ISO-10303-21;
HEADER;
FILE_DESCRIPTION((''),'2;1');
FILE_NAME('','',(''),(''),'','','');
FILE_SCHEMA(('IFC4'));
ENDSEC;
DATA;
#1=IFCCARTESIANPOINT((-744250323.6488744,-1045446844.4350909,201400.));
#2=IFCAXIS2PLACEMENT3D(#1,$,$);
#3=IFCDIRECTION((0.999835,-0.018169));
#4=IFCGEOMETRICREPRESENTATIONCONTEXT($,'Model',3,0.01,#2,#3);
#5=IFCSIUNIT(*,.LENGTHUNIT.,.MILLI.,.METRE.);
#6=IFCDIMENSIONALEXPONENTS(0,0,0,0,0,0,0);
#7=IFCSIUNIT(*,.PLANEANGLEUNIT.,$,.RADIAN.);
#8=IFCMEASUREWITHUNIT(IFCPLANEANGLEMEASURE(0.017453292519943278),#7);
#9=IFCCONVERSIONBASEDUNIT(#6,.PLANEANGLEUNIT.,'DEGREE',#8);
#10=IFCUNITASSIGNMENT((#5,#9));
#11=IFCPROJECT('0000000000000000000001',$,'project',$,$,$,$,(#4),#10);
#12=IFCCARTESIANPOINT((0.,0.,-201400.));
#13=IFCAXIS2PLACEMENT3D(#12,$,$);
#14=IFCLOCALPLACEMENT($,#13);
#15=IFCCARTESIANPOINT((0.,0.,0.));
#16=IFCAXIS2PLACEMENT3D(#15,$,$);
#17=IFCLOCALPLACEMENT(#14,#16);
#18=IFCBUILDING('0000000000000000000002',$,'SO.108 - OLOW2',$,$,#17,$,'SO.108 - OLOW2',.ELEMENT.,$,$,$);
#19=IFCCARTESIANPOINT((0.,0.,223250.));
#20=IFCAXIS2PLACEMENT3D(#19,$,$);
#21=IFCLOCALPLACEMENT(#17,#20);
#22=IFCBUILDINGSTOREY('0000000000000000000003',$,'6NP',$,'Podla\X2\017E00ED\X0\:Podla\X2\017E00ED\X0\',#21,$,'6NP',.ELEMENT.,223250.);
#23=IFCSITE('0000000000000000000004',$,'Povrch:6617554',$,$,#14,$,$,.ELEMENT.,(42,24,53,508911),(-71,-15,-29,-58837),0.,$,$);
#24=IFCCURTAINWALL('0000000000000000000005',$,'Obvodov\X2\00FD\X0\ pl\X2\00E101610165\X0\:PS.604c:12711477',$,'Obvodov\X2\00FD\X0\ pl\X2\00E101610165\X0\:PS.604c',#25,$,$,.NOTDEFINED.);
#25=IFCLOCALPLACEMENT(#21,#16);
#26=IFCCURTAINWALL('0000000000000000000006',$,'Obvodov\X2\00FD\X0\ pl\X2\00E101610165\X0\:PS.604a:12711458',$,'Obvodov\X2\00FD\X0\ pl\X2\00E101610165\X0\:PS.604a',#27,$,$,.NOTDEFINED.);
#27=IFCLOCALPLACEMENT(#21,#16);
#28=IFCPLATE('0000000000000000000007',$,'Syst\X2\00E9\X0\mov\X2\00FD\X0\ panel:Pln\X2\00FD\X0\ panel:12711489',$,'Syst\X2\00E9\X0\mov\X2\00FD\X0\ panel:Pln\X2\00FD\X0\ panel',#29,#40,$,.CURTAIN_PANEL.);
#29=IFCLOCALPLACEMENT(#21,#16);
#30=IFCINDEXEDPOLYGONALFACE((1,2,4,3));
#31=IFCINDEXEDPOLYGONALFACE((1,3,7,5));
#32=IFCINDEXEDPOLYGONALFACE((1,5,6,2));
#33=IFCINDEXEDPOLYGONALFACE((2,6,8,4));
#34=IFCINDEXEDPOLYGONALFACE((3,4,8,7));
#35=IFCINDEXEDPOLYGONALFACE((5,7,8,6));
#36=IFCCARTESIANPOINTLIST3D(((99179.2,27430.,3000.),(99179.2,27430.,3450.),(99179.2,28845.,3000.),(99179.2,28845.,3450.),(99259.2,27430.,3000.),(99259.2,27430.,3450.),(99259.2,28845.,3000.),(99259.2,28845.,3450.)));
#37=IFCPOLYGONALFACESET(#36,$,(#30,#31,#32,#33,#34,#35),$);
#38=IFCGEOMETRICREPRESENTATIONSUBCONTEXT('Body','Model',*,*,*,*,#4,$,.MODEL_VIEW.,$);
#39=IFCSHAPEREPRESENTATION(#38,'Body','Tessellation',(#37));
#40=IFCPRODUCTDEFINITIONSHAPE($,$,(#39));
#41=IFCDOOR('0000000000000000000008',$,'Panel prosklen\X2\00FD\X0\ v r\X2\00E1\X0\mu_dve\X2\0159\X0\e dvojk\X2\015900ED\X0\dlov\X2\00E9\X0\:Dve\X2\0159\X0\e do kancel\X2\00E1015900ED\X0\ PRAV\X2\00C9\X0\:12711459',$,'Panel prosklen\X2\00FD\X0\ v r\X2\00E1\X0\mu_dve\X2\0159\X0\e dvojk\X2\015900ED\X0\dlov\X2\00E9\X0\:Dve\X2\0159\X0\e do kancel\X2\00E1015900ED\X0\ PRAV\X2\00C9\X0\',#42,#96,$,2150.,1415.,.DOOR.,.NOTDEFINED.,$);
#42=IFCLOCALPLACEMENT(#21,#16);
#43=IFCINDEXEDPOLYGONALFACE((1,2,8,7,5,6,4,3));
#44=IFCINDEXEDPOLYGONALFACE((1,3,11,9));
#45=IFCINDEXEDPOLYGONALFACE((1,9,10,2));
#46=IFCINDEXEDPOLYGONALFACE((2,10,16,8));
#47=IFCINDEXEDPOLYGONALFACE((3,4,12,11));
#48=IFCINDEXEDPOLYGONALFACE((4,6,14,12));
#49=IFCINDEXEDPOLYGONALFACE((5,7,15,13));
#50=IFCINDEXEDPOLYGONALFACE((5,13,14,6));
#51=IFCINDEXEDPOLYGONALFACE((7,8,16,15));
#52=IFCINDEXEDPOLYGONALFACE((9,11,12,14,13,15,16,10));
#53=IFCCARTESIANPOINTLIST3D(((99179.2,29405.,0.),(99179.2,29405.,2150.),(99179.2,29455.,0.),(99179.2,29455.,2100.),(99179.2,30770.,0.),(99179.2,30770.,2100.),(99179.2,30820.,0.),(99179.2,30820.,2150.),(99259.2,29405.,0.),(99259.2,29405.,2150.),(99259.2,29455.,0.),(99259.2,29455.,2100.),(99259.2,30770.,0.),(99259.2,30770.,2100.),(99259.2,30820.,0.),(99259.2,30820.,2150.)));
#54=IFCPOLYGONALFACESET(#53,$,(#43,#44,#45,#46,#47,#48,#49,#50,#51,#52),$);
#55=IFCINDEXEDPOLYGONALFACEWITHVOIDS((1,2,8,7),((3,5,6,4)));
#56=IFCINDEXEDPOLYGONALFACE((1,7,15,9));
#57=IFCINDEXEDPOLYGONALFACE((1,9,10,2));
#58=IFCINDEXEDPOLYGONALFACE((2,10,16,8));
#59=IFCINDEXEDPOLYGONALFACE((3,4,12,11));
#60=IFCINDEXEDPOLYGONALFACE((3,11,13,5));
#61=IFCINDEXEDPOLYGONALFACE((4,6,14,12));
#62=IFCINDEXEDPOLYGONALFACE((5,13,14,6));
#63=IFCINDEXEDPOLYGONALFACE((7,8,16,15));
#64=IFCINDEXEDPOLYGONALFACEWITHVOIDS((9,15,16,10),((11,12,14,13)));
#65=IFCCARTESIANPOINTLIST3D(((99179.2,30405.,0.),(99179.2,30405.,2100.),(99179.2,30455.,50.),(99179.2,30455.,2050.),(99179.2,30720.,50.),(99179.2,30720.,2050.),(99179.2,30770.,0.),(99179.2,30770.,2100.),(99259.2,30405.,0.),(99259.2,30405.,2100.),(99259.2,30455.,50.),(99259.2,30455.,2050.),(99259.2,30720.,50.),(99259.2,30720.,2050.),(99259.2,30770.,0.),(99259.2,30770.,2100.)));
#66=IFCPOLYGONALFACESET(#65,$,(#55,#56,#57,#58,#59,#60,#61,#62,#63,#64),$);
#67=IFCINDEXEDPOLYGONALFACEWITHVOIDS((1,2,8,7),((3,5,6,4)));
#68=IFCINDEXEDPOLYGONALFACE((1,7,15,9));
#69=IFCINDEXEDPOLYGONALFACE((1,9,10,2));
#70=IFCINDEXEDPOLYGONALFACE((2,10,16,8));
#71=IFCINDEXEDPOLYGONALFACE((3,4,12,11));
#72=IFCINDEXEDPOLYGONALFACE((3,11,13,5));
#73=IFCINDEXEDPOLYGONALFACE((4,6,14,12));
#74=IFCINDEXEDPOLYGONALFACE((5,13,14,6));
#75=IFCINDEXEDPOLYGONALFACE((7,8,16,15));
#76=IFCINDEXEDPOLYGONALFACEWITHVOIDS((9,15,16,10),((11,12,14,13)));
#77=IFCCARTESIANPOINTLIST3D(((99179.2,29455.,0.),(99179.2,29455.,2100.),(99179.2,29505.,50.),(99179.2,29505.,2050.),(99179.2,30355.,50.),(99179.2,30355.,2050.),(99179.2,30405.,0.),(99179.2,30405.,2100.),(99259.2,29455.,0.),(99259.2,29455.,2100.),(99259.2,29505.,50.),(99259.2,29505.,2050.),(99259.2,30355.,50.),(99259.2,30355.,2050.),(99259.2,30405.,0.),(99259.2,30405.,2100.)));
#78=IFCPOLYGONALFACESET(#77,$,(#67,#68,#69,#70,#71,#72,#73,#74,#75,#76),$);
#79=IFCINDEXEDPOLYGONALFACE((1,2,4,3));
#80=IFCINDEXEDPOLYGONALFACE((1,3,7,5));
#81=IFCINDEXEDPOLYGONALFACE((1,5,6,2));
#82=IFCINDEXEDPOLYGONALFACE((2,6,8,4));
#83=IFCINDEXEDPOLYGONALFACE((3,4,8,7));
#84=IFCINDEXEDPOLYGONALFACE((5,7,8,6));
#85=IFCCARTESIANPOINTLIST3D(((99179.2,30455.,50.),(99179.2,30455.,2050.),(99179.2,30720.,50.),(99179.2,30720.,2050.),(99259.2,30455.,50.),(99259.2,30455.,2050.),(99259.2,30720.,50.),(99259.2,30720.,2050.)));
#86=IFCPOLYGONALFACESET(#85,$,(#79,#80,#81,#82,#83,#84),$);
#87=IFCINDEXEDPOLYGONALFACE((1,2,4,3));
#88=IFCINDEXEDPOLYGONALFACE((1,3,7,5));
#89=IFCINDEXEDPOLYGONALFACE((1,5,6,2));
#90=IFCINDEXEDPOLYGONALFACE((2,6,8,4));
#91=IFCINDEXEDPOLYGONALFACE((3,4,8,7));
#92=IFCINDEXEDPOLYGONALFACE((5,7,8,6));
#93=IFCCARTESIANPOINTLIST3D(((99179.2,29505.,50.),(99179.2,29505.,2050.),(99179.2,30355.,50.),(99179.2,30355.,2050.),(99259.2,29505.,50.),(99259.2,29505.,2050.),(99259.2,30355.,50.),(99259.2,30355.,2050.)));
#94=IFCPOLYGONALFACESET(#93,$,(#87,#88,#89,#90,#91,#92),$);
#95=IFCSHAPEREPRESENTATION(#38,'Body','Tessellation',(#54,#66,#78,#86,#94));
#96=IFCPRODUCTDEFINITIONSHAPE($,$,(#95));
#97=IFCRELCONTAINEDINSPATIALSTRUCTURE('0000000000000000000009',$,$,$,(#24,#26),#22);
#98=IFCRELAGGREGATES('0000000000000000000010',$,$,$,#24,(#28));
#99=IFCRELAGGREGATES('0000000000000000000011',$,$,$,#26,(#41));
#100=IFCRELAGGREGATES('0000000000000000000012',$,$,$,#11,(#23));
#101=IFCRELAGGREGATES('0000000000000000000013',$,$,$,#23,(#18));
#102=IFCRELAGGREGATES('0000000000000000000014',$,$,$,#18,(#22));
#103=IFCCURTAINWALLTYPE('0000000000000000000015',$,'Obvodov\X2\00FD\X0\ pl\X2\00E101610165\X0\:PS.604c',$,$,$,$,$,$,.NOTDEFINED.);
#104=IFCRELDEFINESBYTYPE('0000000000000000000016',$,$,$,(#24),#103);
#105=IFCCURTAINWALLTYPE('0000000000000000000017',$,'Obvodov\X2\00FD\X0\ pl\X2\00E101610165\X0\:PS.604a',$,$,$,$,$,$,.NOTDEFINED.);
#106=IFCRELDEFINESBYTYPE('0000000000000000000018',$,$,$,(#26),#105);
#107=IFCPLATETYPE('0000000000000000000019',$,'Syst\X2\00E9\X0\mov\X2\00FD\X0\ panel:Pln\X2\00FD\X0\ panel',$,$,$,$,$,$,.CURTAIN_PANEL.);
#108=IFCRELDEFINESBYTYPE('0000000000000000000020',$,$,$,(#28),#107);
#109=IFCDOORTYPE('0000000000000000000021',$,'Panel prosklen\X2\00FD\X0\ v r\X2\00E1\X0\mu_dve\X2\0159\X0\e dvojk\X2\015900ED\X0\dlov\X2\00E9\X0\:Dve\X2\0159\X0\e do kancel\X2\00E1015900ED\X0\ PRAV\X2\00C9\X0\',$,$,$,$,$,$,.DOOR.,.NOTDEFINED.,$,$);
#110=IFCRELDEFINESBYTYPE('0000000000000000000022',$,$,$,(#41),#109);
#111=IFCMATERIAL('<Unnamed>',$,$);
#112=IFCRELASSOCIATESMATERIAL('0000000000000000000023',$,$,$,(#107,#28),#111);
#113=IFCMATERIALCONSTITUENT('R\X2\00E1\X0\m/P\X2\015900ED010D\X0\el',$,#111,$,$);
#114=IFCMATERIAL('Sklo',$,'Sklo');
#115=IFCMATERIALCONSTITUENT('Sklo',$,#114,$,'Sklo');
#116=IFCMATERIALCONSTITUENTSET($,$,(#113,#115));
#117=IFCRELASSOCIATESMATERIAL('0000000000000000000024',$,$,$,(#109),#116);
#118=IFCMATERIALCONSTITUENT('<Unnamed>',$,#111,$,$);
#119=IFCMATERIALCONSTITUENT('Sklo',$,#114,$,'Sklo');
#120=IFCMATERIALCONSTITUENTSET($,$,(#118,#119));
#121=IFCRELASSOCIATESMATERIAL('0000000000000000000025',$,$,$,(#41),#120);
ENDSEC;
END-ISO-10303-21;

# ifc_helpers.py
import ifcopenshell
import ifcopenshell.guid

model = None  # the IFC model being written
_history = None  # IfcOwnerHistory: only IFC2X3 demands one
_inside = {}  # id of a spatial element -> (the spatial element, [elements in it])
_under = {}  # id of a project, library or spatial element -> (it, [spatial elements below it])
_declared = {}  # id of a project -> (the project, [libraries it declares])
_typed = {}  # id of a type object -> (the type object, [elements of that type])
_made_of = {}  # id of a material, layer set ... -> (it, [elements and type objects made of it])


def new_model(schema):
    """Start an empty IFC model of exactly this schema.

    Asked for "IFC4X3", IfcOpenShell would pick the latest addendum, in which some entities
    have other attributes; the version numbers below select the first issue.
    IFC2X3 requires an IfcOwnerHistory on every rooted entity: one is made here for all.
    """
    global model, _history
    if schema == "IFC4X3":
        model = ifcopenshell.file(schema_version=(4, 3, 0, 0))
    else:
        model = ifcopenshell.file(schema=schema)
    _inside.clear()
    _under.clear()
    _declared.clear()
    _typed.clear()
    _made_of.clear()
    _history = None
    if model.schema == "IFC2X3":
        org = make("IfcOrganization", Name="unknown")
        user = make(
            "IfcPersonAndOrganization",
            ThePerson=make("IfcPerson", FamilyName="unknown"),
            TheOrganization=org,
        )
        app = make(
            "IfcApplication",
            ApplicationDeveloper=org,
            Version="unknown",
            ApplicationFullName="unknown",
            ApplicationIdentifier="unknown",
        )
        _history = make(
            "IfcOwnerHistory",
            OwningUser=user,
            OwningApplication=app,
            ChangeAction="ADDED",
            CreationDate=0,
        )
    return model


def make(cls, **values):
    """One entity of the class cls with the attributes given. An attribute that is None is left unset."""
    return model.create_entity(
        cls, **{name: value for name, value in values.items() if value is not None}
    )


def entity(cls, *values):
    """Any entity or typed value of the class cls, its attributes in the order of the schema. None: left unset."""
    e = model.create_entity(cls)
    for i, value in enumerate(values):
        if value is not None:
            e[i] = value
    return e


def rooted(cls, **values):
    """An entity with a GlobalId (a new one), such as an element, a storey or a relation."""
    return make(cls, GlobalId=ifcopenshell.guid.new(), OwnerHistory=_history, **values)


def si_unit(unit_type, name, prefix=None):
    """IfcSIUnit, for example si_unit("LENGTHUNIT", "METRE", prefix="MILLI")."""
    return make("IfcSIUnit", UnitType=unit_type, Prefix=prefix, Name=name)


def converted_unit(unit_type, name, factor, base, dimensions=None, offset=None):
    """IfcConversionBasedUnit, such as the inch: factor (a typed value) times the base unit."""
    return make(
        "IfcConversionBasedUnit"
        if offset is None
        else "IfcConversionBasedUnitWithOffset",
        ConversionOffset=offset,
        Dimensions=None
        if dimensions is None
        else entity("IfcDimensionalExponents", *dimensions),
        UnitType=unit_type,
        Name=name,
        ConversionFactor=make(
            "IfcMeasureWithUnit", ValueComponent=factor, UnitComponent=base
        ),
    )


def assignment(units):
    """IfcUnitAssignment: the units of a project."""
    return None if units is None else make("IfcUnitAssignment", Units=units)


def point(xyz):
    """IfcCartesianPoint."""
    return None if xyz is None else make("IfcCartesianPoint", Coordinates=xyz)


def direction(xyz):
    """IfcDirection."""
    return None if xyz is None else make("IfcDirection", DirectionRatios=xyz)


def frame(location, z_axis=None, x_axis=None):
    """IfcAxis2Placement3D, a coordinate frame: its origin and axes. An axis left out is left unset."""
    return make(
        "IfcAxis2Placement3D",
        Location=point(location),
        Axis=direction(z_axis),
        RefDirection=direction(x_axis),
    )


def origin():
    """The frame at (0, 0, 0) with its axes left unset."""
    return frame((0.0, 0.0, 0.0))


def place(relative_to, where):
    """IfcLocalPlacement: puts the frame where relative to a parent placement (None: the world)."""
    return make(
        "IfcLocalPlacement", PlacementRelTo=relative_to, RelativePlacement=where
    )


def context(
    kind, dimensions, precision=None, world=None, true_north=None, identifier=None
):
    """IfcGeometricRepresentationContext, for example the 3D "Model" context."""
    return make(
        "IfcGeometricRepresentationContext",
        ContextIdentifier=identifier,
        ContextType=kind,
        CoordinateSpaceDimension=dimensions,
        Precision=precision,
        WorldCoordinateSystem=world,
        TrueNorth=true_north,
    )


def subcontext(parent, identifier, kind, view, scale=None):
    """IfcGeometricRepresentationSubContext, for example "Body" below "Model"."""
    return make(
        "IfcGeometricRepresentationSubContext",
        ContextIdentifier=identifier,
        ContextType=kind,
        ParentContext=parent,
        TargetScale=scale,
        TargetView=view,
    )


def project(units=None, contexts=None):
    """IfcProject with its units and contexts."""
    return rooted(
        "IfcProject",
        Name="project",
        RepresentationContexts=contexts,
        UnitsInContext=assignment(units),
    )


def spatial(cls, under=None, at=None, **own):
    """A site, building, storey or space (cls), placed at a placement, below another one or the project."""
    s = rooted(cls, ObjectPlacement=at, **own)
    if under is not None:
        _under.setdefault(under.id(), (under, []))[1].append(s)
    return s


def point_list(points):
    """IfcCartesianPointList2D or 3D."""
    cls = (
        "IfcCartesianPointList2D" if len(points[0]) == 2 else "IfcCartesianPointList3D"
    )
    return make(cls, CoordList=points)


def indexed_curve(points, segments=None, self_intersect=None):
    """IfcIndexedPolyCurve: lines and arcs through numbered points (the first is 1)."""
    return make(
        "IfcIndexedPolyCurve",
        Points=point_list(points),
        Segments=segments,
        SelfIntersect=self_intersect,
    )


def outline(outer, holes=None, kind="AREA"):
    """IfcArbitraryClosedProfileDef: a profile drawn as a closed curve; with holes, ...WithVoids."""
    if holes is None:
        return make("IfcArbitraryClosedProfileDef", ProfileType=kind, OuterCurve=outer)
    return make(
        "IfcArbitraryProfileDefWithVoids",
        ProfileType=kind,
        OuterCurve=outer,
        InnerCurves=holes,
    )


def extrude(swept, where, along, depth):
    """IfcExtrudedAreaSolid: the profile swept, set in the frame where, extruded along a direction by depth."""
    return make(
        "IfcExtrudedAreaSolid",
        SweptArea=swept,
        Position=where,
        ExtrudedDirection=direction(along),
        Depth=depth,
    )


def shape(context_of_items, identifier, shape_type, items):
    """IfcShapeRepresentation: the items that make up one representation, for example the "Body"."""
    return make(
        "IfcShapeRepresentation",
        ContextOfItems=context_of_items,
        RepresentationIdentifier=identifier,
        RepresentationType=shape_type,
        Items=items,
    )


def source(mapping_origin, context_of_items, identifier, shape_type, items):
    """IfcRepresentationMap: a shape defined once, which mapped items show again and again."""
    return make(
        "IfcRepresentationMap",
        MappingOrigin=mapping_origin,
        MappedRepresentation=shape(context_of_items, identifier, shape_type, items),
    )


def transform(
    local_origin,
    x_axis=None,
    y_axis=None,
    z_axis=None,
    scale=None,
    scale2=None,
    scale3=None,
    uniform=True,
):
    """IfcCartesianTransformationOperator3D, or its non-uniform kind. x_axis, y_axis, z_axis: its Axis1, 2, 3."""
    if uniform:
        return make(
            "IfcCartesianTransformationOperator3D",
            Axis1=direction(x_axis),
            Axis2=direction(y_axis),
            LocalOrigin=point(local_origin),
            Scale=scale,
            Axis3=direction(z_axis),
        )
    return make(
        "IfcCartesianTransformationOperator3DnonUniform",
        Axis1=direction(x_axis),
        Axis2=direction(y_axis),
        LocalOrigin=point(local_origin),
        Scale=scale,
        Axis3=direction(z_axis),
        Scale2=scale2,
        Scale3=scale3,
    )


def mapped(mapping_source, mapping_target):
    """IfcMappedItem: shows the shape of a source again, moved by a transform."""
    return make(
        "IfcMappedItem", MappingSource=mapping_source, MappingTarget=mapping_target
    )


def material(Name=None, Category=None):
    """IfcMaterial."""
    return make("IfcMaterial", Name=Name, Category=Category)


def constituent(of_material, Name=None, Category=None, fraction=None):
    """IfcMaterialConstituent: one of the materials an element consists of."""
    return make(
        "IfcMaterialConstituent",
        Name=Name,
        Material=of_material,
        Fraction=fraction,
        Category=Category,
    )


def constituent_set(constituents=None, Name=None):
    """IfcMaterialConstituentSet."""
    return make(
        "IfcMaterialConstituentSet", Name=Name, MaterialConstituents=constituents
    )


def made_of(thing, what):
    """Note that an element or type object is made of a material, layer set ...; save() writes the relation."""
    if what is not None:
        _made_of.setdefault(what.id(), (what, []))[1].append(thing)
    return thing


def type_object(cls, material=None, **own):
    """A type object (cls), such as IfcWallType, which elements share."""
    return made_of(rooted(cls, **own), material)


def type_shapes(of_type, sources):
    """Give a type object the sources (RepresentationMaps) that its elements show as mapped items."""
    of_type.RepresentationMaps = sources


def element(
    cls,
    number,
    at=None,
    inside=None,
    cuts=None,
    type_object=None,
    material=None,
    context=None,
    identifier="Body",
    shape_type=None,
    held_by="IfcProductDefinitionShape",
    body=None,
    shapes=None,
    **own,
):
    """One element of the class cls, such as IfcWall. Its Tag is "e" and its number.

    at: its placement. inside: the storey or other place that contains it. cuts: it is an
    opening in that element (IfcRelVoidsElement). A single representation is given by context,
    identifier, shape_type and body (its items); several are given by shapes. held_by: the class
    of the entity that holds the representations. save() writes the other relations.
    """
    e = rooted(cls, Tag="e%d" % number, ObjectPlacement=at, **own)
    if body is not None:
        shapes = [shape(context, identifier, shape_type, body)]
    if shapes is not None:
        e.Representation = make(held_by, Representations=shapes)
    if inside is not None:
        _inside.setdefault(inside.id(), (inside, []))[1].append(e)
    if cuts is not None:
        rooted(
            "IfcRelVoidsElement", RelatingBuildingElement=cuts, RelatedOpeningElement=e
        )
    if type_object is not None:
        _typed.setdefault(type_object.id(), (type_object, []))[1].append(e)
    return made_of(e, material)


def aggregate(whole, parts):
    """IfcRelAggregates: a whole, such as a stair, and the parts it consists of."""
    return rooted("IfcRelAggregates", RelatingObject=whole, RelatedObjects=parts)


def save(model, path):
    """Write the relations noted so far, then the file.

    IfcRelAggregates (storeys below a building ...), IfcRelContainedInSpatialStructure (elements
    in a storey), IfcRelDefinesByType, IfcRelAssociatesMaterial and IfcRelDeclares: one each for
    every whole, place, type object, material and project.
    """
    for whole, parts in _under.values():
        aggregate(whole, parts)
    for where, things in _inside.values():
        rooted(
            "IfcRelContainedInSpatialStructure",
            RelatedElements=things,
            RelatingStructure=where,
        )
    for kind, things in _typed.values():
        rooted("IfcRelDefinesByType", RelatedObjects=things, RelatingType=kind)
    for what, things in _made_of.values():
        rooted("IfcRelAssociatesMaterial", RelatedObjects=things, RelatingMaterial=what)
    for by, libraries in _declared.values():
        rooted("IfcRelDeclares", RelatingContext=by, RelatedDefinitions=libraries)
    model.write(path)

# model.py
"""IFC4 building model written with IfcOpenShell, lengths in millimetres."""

from ifc_helpers import new_model, entity, si_unit, converted_unit, direction, frame, origin, place, context, subcontext, project, spatial, indexed_curve, outline, extrude, source, transform, mapped, material, constituent, constituent_set, type_object, type_shapes, element, aggregate, save


model = new_model("IFC4")

# Units and contexts
model_context = context("Model", 3, precision=0.01, world=frame((-744250323.6488744, -1045446844.4350909, 201400.0)), true_north=direction((0.999835, -0.018169)))
body_context = subcontext(model_context, "Body", "Model", "MODEL_VIEW")
ifc_project = project(units=[si_unit("LENGTHUNIT", "METRE", prefix="MILLI"), converted_unit("PLANEANGLEUNIT", "DEGREE", entity("IfcPlaneAngleMeasure", 0.017453292519943278), si_unit("PLANEANGLEUNIT", "RADIAN"), dimensions=[0, 0, 0, 0, 0, 0, 0])], contexts=[model_context])

# Site, building, storey
site_placement = place(None, frame((0.0, 0.0, -201400.0)))
site = spatial("IfcSite", under=ifc_project, at=site_placement, Name="Povrch:6617554", CompositionType="ELEMENT", RefLatitude=(42, 24, 53, 508911), RefLongitude=(-71, -15, -29, -58837), RefElevation=0.0)
building_placement = place(site_placement, origin())
building = spatial("IfcBuilding", under=site, at=building_placement, Name="SO.108 - OLOW2", LongName="SO.108 - OLOW2", CompositionType="ELEMENT")
storey_placement = place(building_placement, frame((0.0, 0.0, 223250.0)))
storey = spatial("IfcBuildingStorey", under=building, at=storey_placement, Name="6NP", ObjectType="Podlaží:Podlaží", LongName="6NP", CompositionType="ELEMENT", Elevation=223250.0)

# Curtain wall
curtain_wall_type_1 = type_object("IfcCurtainWallType", Name="Obvodový plášť:PS.604c", PredefinedType="NOTDEFINED")
curtain_wall_1_placement = place(storey_placement, frame((0.0, 0.0, -223250.0)))
curtain_wall_1 = element("IfcCurtainWall", 1, at=curtain_wall_1_placement, inside=storey, type_object=curtain_wall_type_1, Name="Obvodový plášť:PS.604c:12711477", ObjectType="Obvodový plášť:PS.604c", PredefinedType="NOTDEFINED")
ifc_material_1 = material(Name="<Unnamed>")

# Curtain wall
curtain_wall_type_2 = type_object("IfcCurtainWallType", Name="Obvodový plášť:PS.604a", PredefinedType="NOTDEFINED")
curtain_wall_2_placement = place(storey_placement, frame((0.0, 0.0, -223250.0)))
curtain_wall_2 = element("IfcCurtainWall", 2, at=curtain_wall_2_placement, inside=storey, type_object=curtain_wall_type_2, Name="Obvodový plášť:PS.604a:12711458", ObjectType="Obvodový plášť:PS.604a", PredefinedType="NOTDEFINED")

# Plate
ifc_material_2 = material(Name="Sklo", Category="Sklo")
plate_type_1 = type_object("IfcPlateType", Name="Systémový panel:Plný panel", PredefinedType="CURTAIN_PANEL", material=ifc_material_1)
shared_shape_1 = source(origin(), body_context, "Body", "SweptSolid", [
    extrude(outline(indexed_curve([(-40.0, -707.5), (40.0, -707.5), (40.0, 707.5), (-40.0, 707.5), (-40.0, -707.5)], self_intersect=False)), frame((0.0, 0.0, 0.0), z_axis=(0.0, 0.0, 1.0), x_axis=(0.0, 1.0, 0.0)), (0.0, 0.0, 1.0), 450.0),
])
type_shapes(plate_type_1, [shared_shape_1])
plate_1_placement = place(curtain_wall_1_placement, frame((99219.2, 28137.5, 226250.0), z_axis=(0.0, 0.0, 1.0), x_axis=(0.0, -1.0, 0.0)))
plate_1 = element("IfcPlate", 3, at=plate_1_placement, type_object=plate_type_1, material=ifc_material_1, Name="Systémový panel:Plný panel:12711489", ObjectType="Systémový panel:Plný panel", PredefinedType="CURTAIN_PANEL", context=body_context, shape_type="MappedRepresentation", body=[
    mapped(shared_shape_1, transform((0.0, 0.0, 0.0), scale=1.0)),
])
aggregate(curtain_wall_1, [plate_1])

# Door
ifc_constituent_1 = constituent(ifc_material_1, Name="<Unnamed>")
ifc_constituent_2 = constituent(ifc_material_2, Name="Sklo", Category="Sklo")
ifc_constituent_set_1 = constituent_set(constituents=[ifc_constituent_1, ifc_constituent_2])
ifc_constituent_3 = constituent(ifc_material_1, Name="Rám/Příčel")
ifc_constituent_4 = constituent(ifc_material_2, Name="Sklo", Category="Sklo")
ifc_constituent_set_2 = constituent_set(constituents=[ifc_constituent_3, ifc_constituent_4])
door_type = type_object("IfcDoorType", Name="Panel prosklený v rámu_dveře dvojkřídlové:Dveře do kanceláří PRAVÉ", OperationType="NOTDEFINED", PredefinedType="DOOR", material=ifc_constituent_set_2)
shared_shape_2 = source(origin(), body_context, "Body", "SweptSolid", [
    extrude(outline(indexed_curve([(-707.5, -1087.5), (707.5, -1087.5), (707.5, 1062.5), (657.5, 1062.5), (657.5, -1037.5), (-657.5, -1037.5), (-657.5, 1062.5), (-707.5, 1062.5), (-707.5, -1087.5)], self_intersect=False)), frame((0.0, -40.0, 1062.5), z_axis=(0.0, 1.0, 0.0), x_axis=(1.0, 0.0, 0.0)), (0.0, 0.0, 1.0), 80.0),
    extrude(outline(indexed_curve([(-1050.0, -182.5), (1050.0, -182.5), (1050.0, 182.5), (-1050.0, 182.5), (-1050.0, -182.5)], self_intersect=False), holes=[indexed_curve([(-1000.0, -132.5), (-1000.0, 132.5), (1000.0, 132.5), (1000.0, -132.5), (-1000.0, -132.5)], self_intersect=False)]), frame((475.0, -40.0, 1050.0), z_axis=(0.0, 1.0, 0.0), x_axis=(0.0, 0.0, -1.0)), (0.0, 0.0, 1.0), 80.0),
    extrude(outline(indexed_curve([(-1050.0, -475.0), (1050.0, -475.0), (1050.0, 475.0), (-1050.0, 475.0), (-1050.0, -475.0)], self_intersect=False), holes=[indexed_curve([(-1000.0, -425.0), (-1000.0, 425.0), (1000.0, 425.0), (1000.0, -425.0), (-1000.0, -425.0)], self_intersect=False)]), frame((-182.5, -40.0, 1050.0), z_axis=(0.0, 1.0, 0.0), x_axis=(0.0, 0.0, -1.0)), (0.0, 0.0, 1.0), 80.0),
    extrude(outline(indexed_curve([(-40.0, -132.5), (40.0, -132.5), (40.0, 132.5), (-40.0, 132.5), (-40.0, -132.5)], self_intersect=False)), frame((475.0, 0.0, 50.0), z_axis=(0.0, 0.0, 1.0), x_axis=(0.0, 1.0, 0.0)), (0.0, 0.0, 1.0), 2000.0),
    extrude(outline(indexed_curve([(-40.0, -425.0), (40.0, -425.0), (40.0, 425.0), (-40.0, 425.0), (-40.0, -425.0)], self_intersect=False)), frame((-182.5, 0.0, 50.0), z_axis=(0.0, 0.0, 1.0), x_axis=(0.0, 1.0, 0.0)), (0.0, 0.0, 1.0), 2000.0),
])
type_shapes(door_type, [shared_shape_2])
door_placement = place(curtain_wall_2_placement, frame((99219.2, 30112.5, 223250.0), z_axis=(0.0, 0.0, 1.0), x_axis=(0.0, 1.0, 0.0)))
door = element("IfcDoor", 4, at=door_placement, type_object=door_type, material=ifc_constituent_set_1, Name="Panel prosklený v rámu_dveře dvojkřídlové:Dveře do kanceláří PRAVÉ:12711459", ObjectType="Panel prosklený v rámu_dveře dvojkřídlové:Dveře do kanceláří PRAVÉ", OperationType="NOTDEFINED", OverallHeight=2150.0, OverallWidth=1415.0, PredefinedType="DOOR", context=body_context, shape_type="MappedRepresentation", body=[
    mapped(shared_shape_2, transform((0.0, 0.0, 0.0), scale=1.0)),
])
aggregate(curtain_wall_2, [door])

save(model, "model.ifc")
